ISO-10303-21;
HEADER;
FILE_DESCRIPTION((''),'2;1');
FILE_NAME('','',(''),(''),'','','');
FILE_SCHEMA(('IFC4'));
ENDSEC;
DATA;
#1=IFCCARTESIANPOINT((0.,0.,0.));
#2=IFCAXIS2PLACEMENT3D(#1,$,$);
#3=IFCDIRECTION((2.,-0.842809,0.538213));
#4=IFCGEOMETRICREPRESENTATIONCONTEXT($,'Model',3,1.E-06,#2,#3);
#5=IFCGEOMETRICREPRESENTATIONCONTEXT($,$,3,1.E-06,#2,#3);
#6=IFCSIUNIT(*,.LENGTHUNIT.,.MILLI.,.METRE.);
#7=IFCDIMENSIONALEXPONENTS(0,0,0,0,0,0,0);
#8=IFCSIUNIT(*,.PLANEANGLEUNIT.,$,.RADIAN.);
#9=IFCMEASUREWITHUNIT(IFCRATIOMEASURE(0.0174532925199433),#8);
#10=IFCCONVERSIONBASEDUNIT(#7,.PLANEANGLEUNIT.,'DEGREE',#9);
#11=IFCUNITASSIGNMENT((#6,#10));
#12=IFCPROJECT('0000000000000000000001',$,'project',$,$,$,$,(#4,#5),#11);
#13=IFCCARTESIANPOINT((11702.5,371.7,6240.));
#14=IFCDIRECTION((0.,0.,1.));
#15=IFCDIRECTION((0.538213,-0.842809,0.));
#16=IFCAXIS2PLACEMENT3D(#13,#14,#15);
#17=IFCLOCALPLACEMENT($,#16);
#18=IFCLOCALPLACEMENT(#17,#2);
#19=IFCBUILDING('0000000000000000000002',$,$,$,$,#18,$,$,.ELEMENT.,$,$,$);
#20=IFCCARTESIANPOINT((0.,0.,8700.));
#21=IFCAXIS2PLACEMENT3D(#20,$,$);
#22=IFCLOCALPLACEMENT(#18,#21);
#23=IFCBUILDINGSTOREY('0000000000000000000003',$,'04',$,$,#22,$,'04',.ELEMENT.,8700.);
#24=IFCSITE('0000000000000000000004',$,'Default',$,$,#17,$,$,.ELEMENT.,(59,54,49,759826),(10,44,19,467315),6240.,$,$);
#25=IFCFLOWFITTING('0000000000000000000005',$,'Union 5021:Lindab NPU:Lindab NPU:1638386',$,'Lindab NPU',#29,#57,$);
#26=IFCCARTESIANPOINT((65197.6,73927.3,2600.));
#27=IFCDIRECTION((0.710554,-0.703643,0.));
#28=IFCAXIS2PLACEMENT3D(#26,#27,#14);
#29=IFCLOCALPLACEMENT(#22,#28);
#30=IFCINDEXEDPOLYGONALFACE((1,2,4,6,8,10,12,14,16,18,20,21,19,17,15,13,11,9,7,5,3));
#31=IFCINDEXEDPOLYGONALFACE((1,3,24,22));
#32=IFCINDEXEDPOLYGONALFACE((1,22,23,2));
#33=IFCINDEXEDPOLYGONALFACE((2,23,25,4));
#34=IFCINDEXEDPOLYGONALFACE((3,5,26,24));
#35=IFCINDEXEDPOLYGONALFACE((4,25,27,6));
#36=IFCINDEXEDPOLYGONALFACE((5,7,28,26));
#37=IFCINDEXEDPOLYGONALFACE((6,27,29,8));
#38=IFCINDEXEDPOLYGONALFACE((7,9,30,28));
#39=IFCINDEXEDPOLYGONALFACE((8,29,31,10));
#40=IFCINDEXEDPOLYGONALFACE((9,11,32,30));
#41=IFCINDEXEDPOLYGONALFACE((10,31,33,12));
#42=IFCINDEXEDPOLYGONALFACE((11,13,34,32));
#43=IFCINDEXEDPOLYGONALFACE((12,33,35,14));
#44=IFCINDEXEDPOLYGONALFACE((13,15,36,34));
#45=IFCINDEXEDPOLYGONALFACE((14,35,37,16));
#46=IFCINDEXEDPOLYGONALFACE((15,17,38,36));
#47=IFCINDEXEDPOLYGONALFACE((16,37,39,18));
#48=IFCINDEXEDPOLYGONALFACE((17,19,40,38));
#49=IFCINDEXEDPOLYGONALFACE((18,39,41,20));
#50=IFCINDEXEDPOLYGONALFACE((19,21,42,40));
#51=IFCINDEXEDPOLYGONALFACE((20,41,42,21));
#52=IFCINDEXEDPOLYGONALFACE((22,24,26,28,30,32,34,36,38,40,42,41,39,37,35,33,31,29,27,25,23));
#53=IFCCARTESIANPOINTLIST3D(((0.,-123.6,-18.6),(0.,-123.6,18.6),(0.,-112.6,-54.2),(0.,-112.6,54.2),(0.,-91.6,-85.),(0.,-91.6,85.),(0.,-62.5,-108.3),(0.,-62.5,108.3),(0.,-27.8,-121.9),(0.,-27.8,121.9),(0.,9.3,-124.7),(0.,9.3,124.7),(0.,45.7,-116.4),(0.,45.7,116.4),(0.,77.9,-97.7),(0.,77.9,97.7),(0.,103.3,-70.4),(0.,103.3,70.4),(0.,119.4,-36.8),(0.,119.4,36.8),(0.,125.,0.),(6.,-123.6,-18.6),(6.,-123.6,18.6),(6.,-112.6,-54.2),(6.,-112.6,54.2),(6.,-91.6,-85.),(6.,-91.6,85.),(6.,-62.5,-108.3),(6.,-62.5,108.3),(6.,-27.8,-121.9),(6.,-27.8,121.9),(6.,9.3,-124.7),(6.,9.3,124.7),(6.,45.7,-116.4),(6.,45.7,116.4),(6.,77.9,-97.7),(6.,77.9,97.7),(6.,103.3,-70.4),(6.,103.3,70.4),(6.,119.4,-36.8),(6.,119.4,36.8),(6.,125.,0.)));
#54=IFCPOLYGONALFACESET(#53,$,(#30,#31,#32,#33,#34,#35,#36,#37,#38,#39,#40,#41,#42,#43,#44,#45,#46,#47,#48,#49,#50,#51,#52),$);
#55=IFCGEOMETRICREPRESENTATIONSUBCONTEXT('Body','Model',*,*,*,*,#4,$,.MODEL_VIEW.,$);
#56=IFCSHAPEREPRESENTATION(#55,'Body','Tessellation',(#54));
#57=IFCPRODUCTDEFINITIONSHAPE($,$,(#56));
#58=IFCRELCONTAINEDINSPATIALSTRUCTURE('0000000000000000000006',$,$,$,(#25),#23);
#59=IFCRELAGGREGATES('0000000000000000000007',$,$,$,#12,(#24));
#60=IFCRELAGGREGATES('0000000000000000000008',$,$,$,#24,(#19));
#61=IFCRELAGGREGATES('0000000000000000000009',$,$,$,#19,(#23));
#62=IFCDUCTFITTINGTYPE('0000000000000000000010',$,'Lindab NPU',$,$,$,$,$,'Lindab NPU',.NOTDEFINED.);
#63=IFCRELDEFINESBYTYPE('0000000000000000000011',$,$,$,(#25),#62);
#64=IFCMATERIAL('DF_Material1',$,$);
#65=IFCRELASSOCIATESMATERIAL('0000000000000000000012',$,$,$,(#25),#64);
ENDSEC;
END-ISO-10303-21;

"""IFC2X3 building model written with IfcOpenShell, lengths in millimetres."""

from ifc_helpers import new_model, entity, si_unit, converted_unit, direction, frame, frame_2d, origin, place, context, subcontext, project, spatial, circle, extrude, source, transform, mapped, material, type_object, type_shapes, element, save


model = new_model("IFC2X3")

# Units and contexts
model_context = context("Model", 3, precision=1e-06, world=origin(), true_north=direction((2.0, -0.842809, 0.538213)))
context_of_model = context(None, 3, precision=1e-06, world=origin(), true_north=direction((2.0, -0.842809, 0.538213)))
body_context = subcontext(model_context, "Body", "Model", "MODEL_VIEW")
ifc_project = project(units=[si_unit("LENGTHUNIT", "METRE", prefix="MILLI"), converted_unit("PLANEANGLEUNIT", "DEGREE", entity("IfcRatioMeasure", 0.0174532925199433), si_unit("PLANEANGLEUNIT", "RADIAN"), dimensions=[0, 0, 0, 0, 0, 0, 0])], contexts=[model_context, context_of_model])

# Site, building, storey
site_placement = place(None, frame((11702.5, 371.7, 6240.0), z_axis=(0.0, 0.0, 1.0), x_axis=(0.538213, -0.842809, 0.0)))
site = spatial("IfcSite", under=ifc_project, at=site_placement, Name="Default", CompositionType="ELEMENT", RefLatitude=(59, 54, 49, 759826), RefLongitude=(10, 44, 19, 467315), RefElevation=6240.0)
building_placement = place(site_placement, origin())
building = spatial("IfcBuilding", under=site, at=building_placement, CompositionType="ELEMENT")
storey_placement = place(building_placement, frame((0.0, 0.0, 8700.0)))
storey = spatial("IfcBuildingStorey", under=building, at=storey_placement, Name="04", LongName="04", CompositionType="ELEMENT", Elevation=8700.0)

# Shared definitions
ifc_material = material(Name="DF_Material1")

# Flow fitting
duct_fitting_type_1 = type_object("IfcDuctFittingType", Name="Lindab NPU", ElementType="Lindab NPU", PredefinedType="NOTDEFINED")
shared_shape_1 = source(origin(), body_context, "Body", "SweptSolid", [
    extrude(circle(Radius=125.0, at=frame_2d((0.0, 0.0), x_axis=(1.0, 0.0))), frame((0.0, 0.0, 0.0), z_axis=(1.0, 0.0, 0.0), x_axis=(0.0, 1.0, 0.0)), (0.0, 0.0, 1.0), 6.0),
])
type_shapes(duct_fitting_type_1, [shared_shape_1])
flow_fitting_placement = place(storey_placement, frame((65197.6, 73927.3, 2600.0), z_axis=(0.710554, -0.703643, 0.0), x_axis=(0.0, 0.0, 1.0)))
element("IfcFlowFitting", 1, at=flow_fitting_placement, inside=storey, type_object=duct_fitting_type_1, material=ifc_material, Name="Union 5021:Lindab NPU:Lindab NPU:1638386", ObjectType="Lindab NPU", context=body_context, shape_type="MappedRepresentation", body=[
    mapped(shared_shape_1, transform((0.0, 0.0, 0.0), scale=1.0)),
])

save(model, "model.ifc")
